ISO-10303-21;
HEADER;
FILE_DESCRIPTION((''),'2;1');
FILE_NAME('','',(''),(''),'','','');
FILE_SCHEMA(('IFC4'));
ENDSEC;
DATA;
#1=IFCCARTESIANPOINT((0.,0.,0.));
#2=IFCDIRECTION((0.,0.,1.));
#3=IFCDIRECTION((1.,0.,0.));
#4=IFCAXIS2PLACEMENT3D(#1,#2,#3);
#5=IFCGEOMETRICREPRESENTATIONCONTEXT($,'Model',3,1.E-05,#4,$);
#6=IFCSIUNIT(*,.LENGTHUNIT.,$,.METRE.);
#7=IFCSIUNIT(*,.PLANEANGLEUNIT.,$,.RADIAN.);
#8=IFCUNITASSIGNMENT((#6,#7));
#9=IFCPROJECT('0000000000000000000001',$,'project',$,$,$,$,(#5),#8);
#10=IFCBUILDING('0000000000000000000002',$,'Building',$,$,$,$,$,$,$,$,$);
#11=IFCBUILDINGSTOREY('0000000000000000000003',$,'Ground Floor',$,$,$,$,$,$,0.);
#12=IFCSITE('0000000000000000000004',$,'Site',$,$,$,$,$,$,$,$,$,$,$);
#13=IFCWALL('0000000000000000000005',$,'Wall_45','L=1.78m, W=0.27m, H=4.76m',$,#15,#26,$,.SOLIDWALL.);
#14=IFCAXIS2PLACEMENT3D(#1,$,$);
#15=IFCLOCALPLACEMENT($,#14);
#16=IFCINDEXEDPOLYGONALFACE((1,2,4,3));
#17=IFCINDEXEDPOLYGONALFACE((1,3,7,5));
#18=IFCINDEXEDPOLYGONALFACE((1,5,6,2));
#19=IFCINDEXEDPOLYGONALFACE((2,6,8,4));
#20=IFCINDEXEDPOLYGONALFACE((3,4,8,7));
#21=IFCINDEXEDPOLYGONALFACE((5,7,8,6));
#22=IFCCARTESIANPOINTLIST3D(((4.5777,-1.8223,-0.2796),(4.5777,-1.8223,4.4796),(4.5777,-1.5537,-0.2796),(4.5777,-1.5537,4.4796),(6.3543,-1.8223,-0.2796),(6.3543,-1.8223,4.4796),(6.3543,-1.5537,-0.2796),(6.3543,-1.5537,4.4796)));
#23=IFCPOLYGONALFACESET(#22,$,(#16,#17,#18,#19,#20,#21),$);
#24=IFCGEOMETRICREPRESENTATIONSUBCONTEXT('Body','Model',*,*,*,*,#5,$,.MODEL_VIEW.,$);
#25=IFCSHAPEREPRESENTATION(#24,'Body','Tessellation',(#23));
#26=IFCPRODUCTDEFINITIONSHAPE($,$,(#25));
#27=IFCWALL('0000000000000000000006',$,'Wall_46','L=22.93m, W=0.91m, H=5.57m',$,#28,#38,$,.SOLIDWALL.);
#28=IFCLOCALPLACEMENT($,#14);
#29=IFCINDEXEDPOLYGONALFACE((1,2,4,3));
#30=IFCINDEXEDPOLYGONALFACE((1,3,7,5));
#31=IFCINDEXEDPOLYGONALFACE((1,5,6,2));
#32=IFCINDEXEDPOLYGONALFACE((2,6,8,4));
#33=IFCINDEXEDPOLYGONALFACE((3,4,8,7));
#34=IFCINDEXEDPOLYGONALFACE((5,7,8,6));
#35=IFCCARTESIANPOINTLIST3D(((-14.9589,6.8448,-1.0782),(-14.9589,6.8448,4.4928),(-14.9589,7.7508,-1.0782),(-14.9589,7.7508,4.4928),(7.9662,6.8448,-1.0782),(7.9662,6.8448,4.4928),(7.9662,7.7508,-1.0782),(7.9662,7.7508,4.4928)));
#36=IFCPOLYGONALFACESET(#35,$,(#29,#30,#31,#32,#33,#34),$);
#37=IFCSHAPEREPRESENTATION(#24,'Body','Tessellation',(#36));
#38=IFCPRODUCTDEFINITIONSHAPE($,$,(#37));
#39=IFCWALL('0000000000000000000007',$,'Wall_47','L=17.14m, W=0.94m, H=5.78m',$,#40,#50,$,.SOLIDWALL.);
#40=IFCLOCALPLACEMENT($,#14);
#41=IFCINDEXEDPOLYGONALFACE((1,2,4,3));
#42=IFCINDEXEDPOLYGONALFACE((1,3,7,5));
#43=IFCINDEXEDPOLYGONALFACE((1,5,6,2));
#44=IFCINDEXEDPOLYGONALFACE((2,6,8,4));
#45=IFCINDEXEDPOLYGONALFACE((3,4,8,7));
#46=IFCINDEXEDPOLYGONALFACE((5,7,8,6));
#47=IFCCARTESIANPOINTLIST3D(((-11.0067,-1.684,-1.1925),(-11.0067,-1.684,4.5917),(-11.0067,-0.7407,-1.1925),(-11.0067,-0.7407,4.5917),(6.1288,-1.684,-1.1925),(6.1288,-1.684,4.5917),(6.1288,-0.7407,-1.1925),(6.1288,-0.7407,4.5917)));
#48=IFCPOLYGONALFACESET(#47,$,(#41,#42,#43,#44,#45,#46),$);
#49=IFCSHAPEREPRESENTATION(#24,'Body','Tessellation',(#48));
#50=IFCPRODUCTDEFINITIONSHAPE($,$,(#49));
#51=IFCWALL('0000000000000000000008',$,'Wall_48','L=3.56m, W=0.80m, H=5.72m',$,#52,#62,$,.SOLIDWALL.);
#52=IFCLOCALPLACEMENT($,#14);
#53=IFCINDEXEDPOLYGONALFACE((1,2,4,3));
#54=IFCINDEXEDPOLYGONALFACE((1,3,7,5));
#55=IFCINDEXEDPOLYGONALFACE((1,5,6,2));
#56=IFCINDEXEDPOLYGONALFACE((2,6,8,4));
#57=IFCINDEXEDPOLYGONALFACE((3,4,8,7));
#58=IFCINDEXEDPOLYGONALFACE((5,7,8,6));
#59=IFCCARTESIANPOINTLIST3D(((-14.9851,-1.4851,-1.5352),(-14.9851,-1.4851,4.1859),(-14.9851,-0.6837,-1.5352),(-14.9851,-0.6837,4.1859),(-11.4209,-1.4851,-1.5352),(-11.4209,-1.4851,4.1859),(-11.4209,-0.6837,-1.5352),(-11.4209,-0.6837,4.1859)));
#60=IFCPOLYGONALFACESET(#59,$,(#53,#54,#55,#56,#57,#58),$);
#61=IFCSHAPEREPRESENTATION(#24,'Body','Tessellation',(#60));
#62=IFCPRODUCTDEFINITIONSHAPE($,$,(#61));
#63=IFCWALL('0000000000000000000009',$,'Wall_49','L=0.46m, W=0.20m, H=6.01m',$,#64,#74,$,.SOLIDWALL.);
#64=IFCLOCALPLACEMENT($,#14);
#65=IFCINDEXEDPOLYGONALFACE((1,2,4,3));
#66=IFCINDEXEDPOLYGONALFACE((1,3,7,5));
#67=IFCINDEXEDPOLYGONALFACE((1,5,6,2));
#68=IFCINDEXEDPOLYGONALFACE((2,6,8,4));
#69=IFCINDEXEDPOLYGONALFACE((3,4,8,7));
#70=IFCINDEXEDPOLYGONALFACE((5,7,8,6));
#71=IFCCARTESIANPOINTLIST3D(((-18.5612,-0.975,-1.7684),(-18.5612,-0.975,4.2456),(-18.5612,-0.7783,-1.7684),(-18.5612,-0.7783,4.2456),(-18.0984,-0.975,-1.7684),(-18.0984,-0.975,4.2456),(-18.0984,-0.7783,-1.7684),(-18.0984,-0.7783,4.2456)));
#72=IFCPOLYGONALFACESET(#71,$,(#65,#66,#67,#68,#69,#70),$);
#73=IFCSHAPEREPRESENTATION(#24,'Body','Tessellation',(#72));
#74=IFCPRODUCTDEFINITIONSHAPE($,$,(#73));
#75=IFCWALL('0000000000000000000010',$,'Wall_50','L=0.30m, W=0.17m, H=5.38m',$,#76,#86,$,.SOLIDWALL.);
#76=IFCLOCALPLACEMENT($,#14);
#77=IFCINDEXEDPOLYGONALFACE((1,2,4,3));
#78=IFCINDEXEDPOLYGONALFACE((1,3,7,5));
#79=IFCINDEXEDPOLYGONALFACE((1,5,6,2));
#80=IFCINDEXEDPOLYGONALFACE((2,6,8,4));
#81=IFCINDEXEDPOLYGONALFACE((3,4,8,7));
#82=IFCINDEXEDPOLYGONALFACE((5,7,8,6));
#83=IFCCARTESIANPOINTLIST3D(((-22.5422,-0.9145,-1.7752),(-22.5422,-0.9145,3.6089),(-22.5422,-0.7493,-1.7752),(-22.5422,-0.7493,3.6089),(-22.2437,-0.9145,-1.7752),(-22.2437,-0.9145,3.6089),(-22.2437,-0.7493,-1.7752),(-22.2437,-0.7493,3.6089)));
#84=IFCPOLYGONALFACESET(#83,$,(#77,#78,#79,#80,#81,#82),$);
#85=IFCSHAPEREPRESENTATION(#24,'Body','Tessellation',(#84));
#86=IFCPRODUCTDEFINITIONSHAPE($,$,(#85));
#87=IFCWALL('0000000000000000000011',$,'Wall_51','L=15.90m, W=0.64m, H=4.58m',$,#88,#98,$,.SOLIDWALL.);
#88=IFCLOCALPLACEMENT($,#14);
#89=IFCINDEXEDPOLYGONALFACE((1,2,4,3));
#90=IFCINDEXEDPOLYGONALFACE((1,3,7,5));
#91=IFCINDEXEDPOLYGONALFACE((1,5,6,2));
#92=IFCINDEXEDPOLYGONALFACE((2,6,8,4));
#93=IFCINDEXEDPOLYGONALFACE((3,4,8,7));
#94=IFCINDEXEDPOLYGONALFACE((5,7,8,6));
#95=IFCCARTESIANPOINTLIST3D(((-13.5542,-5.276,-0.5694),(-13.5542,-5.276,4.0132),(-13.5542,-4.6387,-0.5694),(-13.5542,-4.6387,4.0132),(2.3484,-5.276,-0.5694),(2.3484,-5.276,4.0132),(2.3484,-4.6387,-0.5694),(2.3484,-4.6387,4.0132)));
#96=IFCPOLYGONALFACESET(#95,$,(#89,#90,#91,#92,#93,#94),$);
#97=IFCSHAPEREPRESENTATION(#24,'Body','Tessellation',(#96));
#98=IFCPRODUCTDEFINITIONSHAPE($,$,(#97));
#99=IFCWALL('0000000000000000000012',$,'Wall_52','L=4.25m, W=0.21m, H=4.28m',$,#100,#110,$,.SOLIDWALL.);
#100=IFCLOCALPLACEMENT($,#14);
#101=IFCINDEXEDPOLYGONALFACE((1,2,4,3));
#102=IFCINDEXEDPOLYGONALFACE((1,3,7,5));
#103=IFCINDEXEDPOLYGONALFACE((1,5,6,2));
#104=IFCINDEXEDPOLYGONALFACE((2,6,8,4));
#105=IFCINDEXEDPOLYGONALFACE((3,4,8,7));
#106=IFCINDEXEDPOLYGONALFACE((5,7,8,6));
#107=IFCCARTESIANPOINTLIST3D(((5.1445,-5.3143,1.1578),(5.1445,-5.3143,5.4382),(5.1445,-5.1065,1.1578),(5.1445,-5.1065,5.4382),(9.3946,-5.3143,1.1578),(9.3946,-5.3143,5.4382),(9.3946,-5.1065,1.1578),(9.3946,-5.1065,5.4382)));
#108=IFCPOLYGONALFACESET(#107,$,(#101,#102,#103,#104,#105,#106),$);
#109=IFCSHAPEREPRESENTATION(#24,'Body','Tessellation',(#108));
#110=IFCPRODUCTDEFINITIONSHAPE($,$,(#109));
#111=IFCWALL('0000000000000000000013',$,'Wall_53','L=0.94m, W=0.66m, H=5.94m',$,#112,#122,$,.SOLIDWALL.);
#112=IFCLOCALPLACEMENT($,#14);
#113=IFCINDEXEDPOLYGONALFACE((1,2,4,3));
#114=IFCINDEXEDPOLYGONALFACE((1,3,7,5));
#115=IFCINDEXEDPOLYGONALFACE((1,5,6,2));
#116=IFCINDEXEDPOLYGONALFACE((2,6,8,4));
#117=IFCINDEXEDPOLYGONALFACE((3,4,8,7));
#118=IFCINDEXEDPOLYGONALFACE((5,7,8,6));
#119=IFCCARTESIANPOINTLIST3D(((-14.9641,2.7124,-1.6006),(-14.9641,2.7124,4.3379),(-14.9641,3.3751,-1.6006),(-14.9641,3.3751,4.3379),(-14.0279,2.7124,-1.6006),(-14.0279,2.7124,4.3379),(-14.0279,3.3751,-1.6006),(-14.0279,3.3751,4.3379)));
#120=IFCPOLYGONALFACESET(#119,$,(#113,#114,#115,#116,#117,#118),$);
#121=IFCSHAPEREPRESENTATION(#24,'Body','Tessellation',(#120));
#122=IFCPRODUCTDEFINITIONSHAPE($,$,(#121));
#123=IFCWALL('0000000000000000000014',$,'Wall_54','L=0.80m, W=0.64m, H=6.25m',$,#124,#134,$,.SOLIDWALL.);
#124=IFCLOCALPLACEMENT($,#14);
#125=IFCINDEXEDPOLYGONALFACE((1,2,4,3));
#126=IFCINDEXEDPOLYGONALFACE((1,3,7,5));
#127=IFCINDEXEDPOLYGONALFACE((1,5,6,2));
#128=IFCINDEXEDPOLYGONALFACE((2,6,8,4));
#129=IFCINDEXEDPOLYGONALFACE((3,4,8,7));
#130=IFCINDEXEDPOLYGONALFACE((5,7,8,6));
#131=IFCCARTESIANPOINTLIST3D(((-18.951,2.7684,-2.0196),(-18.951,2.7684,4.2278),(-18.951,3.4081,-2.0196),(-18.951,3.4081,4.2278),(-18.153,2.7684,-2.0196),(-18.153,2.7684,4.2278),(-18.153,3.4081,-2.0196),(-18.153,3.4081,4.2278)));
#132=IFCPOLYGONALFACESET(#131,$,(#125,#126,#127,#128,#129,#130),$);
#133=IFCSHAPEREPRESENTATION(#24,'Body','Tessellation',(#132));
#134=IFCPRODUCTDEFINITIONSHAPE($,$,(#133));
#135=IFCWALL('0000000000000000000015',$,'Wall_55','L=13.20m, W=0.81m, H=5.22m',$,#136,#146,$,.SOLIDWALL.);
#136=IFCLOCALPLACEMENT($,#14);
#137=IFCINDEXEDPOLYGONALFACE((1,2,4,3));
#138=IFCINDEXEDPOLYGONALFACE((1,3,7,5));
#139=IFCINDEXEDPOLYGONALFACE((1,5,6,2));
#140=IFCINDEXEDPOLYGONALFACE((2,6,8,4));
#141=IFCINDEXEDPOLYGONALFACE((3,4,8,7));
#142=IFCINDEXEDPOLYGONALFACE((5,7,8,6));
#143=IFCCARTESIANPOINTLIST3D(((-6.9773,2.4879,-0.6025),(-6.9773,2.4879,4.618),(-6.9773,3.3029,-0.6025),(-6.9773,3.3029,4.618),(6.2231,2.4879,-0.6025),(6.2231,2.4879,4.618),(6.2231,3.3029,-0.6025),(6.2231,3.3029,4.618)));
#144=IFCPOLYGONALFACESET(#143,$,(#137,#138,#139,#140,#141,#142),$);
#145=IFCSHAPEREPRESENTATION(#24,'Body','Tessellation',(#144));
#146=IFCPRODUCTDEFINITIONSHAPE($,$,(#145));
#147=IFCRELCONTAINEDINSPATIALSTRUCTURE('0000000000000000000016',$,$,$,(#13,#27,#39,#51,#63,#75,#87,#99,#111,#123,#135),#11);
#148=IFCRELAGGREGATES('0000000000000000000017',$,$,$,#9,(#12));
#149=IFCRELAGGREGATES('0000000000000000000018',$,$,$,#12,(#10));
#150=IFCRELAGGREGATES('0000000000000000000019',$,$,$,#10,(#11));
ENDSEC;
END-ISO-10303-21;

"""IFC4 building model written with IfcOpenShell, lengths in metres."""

from ifc_helpers import new_model, si_unit, frame, origin_with_axes, origin_2d, context, subcontext, project, spatial, rectangle, extrude, element, save


model = new_model("IFC4")

# Units and contexts
model_context = context("Model", 3, precision=1e-05, world=origin_with_axes())
body_context = subcontext(model_context, "Body", "Model", "MODEL_VIEW")
ifc_project = project(units=[si_unit("LENGTHUNIT", "METRE"), si_unit("PLANEANGLEUNIT", "RADIAN")], contexts=[model_context])

# Site, building, storey
site = spatial("IfcSite", under=ifc_project, Name="Site")
building = spatial("IfcBuilding", under=site, Name="Building")
storey = spatial("IfcBuildingStorey", under=building, Name="Ground Floor", Elevation=0.0)

# Walls
element("IfcWall", 1, inside=storey, Name="Wall_45", Description="L=1.78m, W=0.27m, H=4.76m", PredefinedType="SOLIDWALL", context=body_context, shape_type="SweptSolid", body=[
    extrude(rectangle(XDim=1.7765, YDim=0.2686, at=origin_2d()), frame((5.466, -1.688, -0.2796), z_axis=(0.0, 0.0, 1.0), x_axis=(1.0, 0.0, 0.0)), (0.0, 0.0, 1.0), 4.7592),
])
element("IfcWall", 2, inside=storey, Name="Wall_46", Description="L=22.93m, W=0.91m, H=5.57m", PredefinedType="SOLIDWALL", context=body_context, shape_type="SweptSolid", body=[
    extrude(rectangle(XDim=22.9251, YDim=0.906, at=origin_2d()), frame((-3.4964, 7.2978, -1.0782), z_axis=(0.0, 0.0, 1.0), x_axis=(1.0, 0.0, 0.0)), (0.0, 0.0, 1.0), 5.571),
])
element("IfcWall", 3, inside=storey, Name="Wall_47", Description="L=17.14m, W=0.94m, H=5.78m", PredefinedType="SOLIDWALL", context=body_context, shape_type="SweptSolid", body=[
    extrude(rectangle(XDim=17.1355, YDim=0.9433, at=origin_2d()), frame((-2.4389, -1.2124, -1.1925), z_axis=(0.0, 0.0, 1.0), x_axis=(1.0, 0.0, 0.0)), (0.0, 0.0, 1.0), 5.7842),
])
element("IfcWall", 4, inside=storey, Name="Wall_48", Description="L=3.56m, W=0.80m, H=5.72m", PredefinedType="SOLIDWALL", context=body_context, shape_type="SweptSolid", body=[
    extrude(rectangle(XDim=3.5642, YDim=0.8014, at=origin_2d()), frame((-13.203, -1.0844, -1.5352), z_axis=(0.0, 0.0, 1.0), x_axis=(1.0, 0.0, 0.0)), (0.0, 0.0, 1.0), 5.7211),
])
element("IfcWall", 5, inside=storey, Name="Wall_49", Description="L=0.46m, W=0.20m, H=6.01m", PredefinedType="SOLIDWALL", context=body_context, shape_type="SweptSolid", body=[
    extrude(rectangle(XDim=0.4628, YDim=0.1967, at=origin_2d()), frame((-18.3298, -0.8766, -1.7684), z_axis=(0.0, 0.0, 1.0), x_axis=(1.0, 0.0, 0.0)), (0.0, 0.0, 1.0), 6.014),
])
element("IfcWall", 6, inside=storey, Name="Wall_50", Description="L=0.30m, W=0.17m, H=5.38m", PredefinedType="SOLIDWALL", context=body_context, shape_type="SweptSolid", body=[
    extrude(rectangle(XDim=0.2985, YDim=0.1652, at=origin_2d()), frame((-22.3929, -0.8319, -1.7752), z_axis=(0.0, 0.0, 1.0), x_axis=(1.0, 0.0, 0.0)), (0.0, 0.0, 1.0), 5.3841),
])
element("IfcWall", 7, inside=storey, Name="Wall_51", Description="L=15.90m, W=0.64m, H=4.58m", PredefinedType="SOLIDWALL", context=body_context, shape_type="SweptSolid", body=[
    extrude(rectangle(XDim=15.9026, YDim=0.6373, at=origin_2d()), frame((-5.6029, -4.9573, -0.5694), z_axis=(0.0, 0.0, 1.0), x_axis=(1.0, 0.0, 0.0)), (0.0, 0.0, 1.0), 4.5827),
])
element("IfcWall", 8, inside=storey, Name="Wall_52", Description="L=4.25m, W=0.21m, H=4.28m", PredefinedType="SOLIDWALL", context=body_context, shape_type="SweptSolid", body=[
    extrude(rectangle(XDim=4.2501, YDim=0.2079, at=origin_2d()), frame((7.2695, -5.2104, 1.1578), z_axis=(0.0, 0.0, 1.0), x_axis=(1.0, 0.0, 0.0)), (0.0, 0.0, 1.0), 4.2804),
])
element("IfcWall", 9, inside=storey, Name="Wall_53", Description="L=0.94m, W=0.66m, H=5.94m", PredefinedType="SOLIDWALL", context=body_context, shape_type="SweptSolid", body=[
    extrude(rectangle(XDim=0.9362, YDim=0.6626, at=origin_2d()), frame((-14.496, 3.0438, -1.6006), z_axis=(0.0, 0.0, 1.0), x_axis=(1.0, 0.0, 0.0)), (0.0, 0.0, 1.0), 5.9385),
])
element("IfcWall", 10, inside=storey, Name="Wall_54", Description="L=0.80m, W=0.64m, H=6.25m", PredefinedType="SOLIDWALL", context=body_context, shape_type="SweptSolid", body=[
    extrude(rectangle(XDim=0.7979, YDim=0.6396, at=origin_2d()), frame((-18.552, 3.0883, -2.0196), z_axis=(0.0, 0.0, 1.0), x_axis=(1.0, 0.0, 0.0)), (0.0, 0.0, 1.0), 6.2474),
])
element("IfcWall", 11, inside=storey, Name="Wall_55", Description="L=13.20m, W=0.81m, H=5.22m", PredefinedType="SOLIDWALL", context=body_context, shape_type="SweptSolid", body=[
    extrude(rectangle(XDim=13.2003, YDim=0.815, at=origin_2d()), frame((-0.3771, 2.8954, -0.6025), z_axis=(0.0, 0.0, 1.0), x_axis=(1.0, 0.0, 0.0)), (0.0, 0.0, 1.0), 5.2206),
])

save(model, "model.ifc")
